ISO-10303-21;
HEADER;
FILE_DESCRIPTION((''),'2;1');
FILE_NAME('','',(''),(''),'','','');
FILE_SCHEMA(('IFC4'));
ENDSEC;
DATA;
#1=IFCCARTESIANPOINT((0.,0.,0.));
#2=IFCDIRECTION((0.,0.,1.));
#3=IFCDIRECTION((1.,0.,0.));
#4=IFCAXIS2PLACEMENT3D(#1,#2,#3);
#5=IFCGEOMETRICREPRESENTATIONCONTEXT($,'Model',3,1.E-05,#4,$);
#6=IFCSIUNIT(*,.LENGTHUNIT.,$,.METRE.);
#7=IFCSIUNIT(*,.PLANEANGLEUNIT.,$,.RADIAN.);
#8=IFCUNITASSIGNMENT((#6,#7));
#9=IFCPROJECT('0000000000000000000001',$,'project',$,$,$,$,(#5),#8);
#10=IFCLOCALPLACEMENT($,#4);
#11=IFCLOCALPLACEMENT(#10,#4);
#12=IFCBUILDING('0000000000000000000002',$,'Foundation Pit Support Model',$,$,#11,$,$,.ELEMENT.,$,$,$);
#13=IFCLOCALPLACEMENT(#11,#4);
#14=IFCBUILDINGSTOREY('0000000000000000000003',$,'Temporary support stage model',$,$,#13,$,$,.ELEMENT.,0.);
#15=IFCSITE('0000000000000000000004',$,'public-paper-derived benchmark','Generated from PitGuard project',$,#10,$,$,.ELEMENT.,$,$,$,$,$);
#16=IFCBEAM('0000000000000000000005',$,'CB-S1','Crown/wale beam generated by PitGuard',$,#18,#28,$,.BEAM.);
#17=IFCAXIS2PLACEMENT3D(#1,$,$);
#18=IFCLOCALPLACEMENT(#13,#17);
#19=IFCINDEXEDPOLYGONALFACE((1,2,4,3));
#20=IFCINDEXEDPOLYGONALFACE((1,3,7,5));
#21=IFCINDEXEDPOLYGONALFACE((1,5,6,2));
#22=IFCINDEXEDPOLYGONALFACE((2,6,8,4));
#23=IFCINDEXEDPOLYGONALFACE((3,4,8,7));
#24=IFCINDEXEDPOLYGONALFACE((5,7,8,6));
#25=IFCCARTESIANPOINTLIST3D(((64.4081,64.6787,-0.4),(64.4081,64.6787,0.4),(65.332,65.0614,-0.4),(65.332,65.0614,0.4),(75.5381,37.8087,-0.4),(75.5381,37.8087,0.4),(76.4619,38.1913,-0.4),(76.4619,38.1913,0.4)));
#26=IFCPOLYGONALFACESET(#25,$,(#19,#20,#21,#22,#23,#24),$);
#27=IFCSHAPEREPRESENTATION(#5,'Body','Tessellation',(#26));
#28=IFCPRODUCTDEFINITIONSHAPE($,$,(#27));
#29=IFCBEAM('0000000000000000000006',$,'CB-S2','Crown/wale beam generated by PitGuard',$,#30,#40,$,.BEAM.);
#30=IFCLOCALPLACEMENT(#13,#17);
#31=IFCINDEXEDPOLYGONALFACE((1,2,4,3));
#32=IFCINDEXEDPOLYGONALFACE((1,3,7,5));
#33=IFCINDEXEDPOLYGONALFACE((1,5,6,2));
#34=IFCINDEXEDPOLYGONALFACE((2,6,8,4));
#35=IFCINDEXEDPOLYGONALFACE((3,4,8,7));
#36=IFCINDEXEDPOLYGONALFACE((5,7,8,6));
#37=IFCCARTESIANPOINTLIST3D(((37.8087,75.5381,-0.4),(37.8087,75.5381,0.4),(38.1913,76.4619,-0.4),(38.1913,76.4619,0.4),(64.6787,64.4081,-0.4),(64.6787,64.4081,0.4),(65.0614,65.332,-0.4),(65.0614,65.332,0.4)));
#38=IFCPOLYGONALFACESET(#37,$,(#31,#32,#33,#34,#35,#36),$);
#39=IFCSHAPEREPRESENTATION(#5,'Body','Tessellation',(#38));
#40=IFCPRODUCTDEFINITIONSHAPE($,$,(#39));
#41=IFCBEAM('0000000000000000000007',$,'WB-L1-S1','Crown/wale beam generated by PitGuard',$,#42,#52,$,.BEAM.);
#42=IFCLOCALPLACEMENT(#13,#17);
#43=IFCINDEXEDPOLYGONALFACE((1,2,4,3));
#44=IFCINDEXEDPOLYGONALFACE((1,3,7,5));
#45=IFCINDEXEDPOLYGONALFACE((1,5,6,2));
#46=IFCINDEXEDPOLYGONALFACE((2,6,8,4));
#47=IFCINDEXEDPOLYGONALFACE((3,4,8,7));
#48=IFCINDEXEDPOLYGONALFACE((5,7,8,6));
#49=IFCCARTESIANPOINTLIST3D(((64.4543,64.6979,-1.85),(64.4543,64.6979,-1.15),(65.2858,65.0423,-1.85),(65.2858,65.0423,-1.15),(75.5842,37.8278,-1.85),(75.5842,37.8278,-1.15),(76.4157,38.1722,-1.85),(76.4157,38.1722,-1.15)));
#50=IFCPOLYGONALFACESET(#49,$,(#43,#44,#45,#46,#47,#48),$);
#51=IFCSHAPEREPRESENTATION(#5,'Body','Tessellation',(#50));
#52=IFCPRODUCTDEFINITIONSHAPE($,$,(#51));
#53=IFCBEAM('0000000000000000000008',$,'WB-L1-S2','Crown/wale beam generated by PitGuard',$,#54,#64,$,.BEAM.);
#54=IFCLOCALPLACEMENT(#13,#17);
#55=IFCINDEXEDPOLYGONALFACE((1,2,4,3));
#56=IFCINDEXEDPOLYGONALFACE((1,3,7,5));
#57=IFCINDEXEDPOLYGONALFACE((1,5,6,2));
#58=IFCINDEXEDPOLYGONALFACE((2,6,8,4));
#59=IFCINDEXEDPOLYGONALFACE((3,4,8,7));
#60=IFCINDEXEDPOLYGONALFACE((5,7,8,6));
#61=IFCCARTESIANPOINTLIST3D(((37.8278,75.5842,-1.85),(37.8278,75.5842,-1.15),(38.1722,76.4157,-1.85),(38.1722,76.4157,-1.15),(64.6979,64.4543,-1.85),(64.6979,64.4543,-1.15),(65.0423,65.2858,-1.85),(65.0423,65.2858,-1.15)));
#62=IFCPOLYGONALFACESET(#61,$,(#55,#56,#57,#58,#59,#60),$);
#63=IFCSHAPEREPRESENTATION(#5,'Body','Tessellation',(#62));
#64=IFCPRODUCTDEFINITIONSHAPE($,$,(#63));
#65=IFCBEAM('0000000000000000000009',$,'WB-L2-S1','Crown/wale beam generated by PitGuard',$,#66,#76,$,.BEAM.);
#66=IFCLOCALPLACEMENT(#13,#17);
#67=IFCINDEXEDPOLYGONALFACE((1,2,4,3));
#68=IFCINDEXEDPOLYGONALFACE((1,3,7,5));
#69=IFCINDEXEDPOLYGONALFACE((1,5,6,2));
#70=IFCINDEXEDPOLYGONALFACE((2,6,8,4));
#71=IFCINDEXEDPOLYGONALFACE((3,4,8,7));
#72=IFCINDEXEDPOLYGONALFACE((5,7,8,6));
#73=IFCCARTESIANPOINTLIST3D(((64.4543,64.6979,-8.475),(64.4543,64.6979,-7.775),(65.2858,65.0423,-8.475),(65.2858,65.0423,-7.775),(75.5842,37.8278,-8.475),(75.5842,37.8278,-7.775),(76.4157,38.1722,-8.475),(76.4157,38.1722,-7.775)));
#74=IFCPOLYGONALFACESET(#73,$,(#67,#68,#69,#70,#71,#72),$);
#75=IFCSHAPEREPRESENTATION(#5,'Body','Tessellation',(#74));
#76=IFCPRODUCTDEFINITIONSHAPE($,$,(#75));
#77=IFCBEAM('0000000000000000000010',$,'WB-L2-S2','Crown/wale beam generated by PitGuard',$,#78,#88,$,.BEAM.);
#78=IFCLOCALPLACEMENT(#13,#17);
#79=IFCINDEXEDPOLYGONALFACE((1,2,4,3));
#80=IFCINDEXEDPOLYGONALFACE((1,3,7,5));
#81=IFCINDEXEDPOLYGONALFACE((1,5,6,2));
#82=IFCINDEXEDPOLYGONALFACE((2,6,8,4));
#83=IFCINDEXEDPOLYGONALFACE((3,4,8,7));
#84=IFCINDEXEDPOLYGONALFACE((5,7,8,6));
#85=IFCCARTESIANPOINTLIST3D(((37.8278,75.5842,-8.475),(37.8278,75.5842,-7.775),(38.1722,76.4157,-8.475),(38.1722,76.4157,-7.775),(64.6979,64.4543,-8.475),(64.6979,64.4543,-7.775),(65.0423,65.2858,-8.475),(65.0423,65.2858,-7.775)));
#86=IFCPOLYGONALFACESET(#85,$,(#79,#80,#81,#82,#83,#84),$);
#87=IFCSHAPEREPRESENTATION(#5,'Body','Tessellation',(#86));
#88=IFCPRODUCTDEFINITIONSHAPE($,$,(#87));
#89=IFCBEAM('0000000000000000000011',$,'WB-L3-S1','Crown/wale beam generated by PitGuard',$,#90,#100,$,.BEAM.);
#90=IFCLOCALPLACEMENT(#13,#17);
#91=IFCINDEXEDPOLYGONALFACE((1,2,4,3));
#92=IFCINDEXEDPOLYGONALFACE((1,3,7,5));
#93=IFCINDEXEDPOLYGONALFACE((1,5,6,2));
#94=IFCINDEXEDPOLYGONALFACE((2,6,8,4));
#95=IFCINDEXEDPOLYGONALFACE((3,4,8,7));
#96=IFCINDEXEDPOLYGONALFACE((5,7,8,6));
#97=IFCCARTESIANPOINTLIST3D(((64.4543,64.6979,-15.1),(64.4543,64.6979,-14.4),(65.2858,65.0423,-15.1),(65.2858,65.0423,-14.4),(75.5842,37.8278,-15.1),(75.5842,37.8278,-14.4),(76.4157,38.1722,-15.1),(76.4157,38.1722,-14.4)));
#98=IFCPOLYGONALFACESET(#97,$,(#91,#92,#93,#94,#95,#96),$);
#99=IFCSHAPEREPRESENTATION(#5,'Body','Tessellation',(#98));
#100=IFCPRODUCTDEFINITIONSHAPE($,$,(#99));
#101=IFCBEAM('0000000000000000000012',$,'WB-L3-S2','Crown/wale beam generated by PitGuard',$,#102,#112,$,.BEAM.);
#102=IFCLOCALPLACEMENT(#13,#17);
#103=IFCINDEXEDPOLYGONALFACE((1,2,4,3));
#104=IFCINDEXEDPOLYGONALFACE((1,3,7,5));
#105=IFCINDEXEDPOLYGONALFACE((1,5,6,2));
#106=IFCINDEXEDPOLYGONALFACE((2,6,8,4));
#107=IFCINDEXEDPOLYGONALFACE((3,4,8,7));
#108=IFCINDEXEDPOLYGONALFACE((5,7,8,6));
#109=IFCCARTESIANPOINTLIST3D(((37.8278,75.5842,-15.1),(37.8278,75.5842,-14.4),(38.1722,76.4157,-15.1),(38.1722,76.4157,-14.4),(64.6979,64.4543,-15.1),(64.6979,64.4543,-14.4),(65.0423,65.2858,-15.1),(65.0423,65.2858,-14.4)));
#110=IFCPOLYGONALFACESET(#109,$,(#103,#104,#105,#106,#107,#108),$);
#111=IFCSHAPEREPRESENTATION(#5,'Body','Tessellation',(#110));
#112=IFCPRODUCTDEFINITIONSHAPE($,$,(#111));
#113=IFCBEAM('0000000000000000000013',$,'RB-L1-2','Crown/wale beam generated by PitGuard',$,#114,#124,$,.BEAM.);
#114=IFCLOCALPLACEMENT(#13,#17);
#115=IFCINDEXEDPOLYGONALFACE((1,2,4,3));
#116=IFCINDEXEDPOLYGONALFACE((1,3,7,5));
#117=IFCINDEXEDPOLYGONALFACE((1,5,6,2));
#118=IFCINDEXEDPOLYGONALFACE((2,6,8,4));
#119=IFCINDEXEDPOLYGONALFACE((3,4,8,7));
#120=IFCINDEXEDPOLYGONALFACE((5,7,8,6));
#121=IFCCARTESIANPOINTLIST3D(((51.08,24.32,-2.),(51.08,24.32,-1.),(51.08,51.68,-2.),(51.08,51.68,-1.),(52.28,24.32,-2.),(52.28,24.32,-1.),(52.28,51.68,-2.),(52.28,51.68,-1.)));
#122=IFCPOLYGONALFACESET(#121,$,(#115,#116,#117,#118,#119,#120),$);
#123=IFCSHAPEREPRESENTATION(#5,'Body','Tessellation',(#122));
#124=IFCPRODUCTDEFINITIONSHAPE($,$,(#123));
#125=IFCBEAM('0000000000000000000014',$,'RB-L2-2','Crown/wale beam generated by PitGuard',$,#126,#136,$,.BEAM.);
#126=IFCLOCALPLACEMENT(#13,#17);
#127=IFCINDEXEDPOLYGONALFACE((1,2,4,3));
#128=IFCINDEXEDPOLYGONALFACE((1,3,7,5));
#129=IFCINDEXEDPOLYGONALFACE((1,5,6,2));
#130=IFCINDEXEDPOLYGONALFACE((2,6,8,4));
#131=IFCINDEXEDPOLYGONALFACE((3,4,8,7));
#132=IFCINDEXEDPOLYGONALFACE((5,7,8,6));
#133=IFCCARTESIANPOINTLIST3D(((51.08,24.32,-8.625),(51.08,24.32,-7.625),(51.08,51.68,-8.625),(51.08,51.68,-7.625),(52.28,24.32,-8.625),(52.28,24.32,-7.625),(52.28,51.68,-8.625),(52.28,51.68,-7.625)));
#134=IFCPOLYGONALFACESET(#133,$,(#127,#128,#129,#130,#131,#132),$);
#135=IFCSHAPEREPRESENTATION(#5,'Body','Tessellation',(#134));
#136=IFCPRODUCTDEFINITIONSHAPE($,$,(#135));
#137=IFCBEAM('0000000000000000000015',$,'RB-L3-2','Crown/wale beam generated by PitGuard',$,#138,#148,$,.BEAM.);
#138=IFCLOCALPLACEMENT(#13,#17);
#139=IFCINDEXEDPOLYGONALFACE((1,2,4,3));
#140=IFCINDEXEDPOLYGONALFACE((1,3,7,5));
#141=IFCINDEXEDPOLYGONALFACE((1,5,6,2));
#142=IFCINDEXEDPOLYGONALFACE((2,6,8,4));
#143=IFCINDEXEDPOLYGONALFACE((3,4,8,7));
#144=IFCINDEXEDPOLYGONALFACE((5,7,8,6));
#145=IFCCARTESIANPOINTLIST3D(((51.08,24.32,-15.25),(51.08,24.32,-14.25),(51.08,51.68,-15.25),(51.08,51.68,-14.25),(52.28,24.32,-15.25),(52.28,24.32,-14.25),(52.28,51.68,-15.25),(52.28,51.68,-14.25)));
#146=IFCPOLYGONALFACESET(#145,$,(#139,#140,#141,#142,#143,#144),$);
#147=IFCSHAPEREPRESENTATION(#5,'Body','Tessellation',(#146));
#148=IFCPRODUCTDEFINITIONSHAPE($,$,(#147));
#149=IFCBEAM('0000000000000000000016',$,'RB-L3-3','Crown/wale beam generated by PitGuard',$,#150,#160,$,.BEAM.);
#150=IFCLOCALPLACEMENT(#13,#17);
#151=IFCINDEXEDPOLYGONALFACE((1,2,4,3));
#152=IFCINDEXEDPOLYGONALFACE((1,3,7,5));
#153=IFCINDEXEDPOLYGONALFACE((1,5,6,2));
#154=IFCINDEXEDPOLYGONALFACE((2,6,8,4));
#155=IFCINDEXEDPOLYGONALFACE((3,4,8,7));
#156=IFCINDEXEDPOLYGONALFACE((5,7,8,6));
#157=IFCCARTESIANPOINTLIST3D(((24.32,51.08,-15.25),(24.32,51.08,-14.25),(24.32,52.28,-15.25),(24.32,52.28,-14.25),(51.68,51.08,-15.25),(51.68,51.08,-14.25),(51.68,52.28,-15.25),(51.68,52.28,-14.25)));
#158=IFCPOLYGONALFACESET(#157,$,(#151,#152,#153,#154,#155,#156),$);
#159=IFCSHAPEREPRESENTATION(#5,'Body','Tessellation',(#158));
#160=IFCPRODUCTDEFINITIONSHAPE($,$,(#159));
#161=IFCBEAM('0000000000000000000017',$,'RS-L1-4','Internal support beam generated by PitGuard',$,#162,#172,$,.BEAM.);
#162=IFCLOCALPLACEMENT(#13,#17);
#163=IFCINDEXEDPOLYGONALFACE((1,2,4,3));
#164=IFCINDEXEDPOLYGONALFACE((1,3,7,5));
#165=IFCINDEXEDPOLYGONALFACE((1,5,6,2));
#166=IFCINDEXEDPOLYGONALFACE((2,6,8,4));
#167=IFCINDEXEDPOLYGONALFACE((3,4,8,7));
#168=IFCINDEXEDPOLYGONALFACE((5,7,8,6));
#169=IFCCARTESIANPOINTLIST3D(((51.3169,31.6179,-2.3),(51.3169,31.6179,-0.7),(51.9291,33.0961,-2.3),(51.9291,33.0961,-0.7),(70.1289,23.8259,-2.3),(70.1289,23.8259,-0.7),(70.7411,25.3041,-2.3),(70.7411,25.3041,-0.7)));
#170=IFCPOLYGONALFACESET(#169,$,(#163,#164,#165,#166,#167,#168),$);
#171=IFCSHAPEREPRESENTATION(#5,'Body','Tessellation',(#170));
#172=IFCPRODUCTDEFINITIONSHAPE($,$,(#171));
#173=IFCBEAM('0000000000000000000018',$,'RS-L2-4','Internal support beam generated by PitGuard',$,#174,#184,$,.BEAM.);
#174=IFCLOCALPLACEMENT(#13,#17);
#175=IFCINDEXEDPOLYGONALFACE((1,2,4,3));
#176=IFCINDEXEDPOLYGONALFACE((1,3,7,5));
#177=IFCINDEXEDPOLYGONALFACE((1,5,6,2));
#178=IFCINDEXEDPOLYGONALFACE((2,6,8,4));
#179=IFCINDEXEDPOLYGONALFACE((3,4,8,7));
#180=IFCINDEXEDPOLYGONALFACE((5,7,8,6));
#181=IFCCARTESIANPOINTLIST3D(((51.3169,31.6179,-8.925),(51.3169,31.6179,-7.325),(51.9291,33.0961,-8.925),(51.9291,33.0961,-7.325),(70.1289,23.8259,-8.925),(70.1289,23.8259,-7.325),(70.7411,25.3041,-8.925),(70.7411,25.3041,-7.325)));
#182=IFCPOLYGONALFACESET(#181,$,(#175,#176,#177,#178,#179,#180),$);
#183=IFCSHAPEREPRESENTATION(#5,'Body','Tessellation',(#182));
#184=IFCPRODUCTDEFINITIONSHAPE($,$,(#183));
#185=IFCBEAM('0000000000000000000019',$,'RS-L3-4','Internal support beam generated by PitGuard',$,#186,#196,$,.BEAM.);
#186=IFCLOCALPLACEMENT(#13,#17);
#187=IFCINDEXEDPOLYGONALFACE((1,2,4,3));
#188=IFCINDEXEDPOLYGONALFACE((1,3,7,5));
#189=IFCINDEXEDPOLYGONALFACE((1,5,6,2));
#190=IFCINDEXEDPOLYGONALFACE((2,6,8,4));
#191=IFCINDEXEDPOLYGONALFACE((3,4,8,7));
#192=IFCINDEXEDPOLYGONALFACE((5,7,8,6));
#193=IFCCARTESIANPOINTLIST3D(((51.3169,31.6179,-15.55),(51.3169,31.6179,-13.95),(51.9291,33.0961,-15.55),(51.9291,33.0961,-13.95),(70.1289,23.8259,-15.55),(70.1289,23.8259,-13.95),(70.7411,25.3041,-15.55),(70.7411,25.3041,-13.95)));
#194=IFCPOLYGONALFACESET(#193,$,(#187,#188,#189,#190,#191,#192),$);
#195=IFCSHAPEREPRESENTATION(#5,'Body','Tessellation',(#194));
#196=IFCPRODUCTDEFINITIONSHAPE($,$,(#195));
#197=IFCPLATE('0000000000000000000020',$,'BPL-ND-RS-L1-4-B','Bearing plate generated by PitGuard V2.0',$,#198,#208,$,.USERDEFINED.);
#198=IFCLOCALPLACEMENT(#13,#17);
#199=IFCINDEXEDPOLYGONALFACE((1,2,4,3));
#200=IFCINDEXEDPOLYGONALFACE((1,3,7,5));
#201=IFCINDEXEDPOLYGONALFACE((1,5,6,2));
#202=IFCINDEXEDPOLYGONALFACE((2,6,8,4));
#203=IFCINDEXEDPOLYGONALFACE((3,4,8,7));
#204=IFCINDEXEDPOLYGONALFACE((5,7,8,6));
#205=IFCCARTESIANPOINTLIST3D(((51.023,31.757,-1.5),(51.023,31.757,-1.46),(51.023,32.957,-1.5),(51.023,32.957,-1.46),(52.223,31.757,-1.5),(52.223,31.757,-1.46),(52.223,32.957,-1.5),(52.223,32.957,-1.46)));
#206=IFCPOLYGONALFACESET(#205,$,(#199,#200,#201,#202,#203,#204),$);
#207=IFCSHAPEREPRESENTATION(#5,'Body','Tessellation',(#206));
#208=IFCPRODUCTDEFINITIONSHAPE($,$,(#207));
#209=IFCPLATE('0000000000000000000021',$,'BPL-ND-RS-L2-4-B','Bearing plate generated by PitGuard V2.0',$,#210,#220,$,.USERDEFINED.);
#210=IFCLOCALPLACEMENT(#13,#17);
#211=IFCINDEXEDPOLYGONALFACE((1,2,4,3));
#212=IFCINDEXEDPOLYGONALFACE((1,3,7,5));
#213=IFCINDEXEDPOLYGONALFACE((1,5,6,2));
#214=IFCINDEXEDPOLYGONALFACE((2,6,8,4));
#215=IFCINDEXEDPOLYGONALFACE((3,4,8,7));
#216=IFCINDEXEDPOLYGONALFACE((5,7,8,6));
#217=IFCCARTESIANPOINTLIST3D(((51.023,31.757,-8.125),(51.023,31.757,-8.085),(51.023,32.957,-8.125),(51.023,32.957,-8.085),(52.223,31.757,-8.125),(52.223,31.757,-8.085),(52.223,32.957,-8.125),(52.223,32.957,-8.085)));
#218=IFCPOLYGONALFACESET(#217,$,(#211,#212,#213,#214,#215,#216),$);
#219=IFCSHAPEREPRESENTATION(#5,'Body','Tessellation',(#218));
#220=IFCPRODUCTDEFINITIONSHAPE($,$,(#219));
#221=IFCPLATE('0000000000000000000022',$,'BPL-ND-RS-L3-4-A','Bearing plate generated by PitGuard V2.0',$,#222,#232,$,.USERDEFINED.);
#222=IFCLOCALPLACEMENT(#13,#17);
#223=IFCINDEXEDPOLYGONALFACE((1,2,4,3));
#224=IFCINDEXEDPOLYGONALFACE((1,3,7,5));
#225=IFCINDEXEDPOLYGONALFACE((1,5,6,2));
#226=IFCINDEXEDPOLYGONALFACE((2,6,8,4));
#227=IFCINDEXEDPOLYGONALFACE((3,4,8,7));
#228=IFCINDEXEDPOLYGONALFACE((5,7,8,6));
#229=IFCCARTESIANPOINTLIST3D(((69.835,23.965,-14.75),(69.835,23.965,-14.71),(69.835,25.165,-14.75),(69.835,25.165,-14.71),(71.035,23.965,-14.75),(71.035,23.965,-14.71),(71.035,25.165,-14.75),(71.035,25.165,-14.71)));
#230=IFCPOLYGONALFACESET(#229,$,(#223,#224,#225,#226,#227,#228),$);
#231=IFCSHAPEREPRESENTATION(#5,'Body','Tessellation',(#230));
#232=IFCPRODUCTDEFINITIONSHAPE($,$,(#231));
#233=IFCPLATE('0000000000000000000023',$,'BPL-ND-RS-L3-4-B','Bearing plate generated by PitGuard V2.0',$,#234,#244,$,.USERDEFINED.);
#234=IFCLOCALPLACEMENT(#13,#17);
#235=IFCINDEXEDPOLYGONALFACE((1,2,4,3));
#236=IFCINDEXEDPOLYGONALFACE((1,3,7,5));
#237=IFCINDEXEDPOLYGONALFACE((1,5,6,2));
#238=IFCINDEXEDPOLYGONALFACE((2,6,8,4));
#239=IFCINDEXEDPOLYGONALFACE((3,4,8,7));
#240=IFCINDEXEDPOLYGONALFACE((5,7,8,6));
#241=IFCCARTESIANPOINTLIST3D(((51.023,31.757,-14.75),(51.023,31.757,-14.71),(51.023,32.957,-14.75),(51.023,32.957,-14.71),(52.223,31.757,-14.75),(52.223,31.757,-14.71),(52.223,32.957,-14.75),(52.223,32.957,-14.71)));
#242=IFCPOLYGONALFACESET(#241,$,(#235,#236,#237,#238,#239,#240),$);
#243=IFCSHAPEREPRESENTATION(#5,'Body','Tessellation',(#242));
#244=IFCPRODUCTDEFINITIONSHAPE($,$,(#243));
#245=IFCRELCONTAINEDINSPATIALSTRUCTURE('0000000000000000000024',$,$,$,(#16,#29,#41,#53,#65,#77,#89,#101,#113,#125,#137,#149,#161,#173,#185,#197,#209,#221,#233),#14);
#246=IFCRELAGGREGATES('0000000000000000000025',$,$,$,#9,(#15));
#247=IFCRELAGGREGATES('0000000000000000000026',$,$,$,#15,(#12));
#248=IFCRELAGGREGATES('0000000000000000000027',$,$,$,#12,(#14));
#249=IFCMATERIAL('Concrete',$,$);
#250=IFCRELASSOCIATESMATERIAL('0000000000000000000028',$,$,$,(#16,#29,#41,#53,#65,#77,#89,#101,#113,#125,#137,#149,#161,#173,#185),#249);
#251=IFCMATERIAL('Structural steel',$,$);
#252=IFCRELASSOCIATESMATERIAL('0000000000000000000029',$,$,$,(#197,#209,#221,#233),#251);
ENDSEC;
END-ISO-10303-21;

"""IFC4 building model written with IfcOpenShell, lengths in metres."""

from ifc_helpers import new_model, si_unit, frame, origin_with_axes, origin_2d, place, context, project, spatial, rectangle, extrude, material, element, save


model = new_model("IFC4")

# Units and contexts
model_context = context("Model", 3, precision=1e-05, world=origin_with_axes())
ifc_project = project(units=[si_unit("LENGTHUNIT", "METRE"), si_unit("PLANEANGLEUNIT", "RADIAN")], contexts=[model_context])

# Site, building, storey
site_placement = place(None, origin_with_axes())
site = spatial("IfcSite", under=ifc_project, at=site_placement, Name="public-paper-derived benchmark", Description="Generated from PitGuard project", CompositionType="ELEMENT")
building_placement = place(site_placement, origin_with_axes())
building = spatial("IfcBuilding", under=site, at=building_placement, Name="Foundation Pit Support Model", CompositionType="ELEMENT")
storey_placement = place(building_placement, origin_with_axes())
storey = spatial("IfcBuildingStorey", under=building, at=storey_placement, Name="Temporary support stage model", CompositionType="ELEMENT", Elevation=0.0)

# Beams
ifc_material_1 = material(Name="Concrete")
for number, where, z_axis, x_axis, name in (
    (1, (70.435, 51.435, -0.4), (0.0, 0.0, 1.0), (-0.382683, 0.92388, 0.0), "CB-S1"),
    (2, (51.435, 70.435, -0.4), (0.0, 0.0, 1.0), (-0.92388, 0.382683, 0.0), "CB-S2"),
):
    element("IfcBeam", number, at=place(storey_placement, frame(where, z_axis=z_axis, x_axis=x_axis)), inside=storey, material=ifc_material_1, Name=name, Description="Crown/wale beam generated by PitGuard", PredefinedType="BEAM", context=model_context, shape_type="SweptSolid", body=[
        extrude(rectangle(XDim=29.0839, YDim=1.0, at=origin_2d()), origin_with_axes(), (0.0, 0.0, 1.0), 0.8),
    ])
for number, where, z_axis, x_axis, name in (
    (3, (70.435, 51.435, -1.85), (0.0, 0.0, 1.0), (-0.382683, 0.92388, 0.0), "WB-L1-S1"),
    (4, (51.435, 70.435, -1.85), (0.0, 0.0, 1.0), (-0.92388, 0.382683, 0.0), "WB-L1-S2"),
    (5, (70.435, 51.435, -8.475), (0.0, 0.0, 1.0), (-0.382683, 0.92388, 0.0), "WB-L2-S1"),
    (6, (51.435, 70.435, -8.475), (0.0, 0.0, 1.0), (-0.92388, 0.382683, 0.0), "WB-L2-S2"),
    (7, (70.435, 51.435, -15.1), (0.0, 0.0, 1.0), (-0.382683, 0.92388, 0.0), "WB-L3-S1"),
    (8, (51.435, 70.435, -15.1), (0.0, 0.0, 1.0), (-0.92388, 0.382683, 0.0), "WB-L3-S2"),
):
    element("IfcBeam", number, at=place(storey_placement, frame(where, z_axis=z_axis, x_axis=x_axis)), inside=storey, material=ifc_material_1, Name=name, Description="Crown/wale beam generated by PitGuard", PredefinedType="BEAM", context=model_context, shape_type="SweptSolid", body=[
        extrude(rectangle(XDim=29.0839, YDim=0.9, at=origin_2d()), origin_with_axes(), (0.0, 0.0, 1.0), 0.7),
    ])
for number, where, z_axis, x_axis, name in (
    (9, (51.68, 38.0, -2.0), (0.0, 0.0, 1.0), (0.0, 1.0, 0.0), "RB-L1-2"),
    (10, (51.68, 38.0, -8.625), (0.0, 0.0, 1.0), (0.0, 1.0, 0.0), "RB-L2-2"),
    (11, (51.68, 38.0, -15.25), (0.0, 0.0, 1.0), (0.0, 1.0, 0.0), "RB-L3-2"),
    (12, (38.0, 51.68, -15.25), (0.0, 0.0, 1.0), (-1.0, 0.0, 0.0), "RB-L3-3"),
):
    element("IfcBeam", number, at=place(storey_placement, frame(where, z_axis=z_axis, x_axis=x_axis)), inside=storey, material=ifc_material_1, Name=name, Description="Crown/wale beam generated by PitGuard", PredefinedType="BEAM", context=model_context, shape_type="SweptSolid", body=[
        extrude(rectangle(XDim=27.36, YDim=1.2, at=origin_2d()), origin_with_axes(), (0.0, 0.0, 1.0), 1.0),
    ])
for number, where, z_axis, x_axis, name in (
    (13, (61.029, 28.461, -2.3), (0.0, 0.0, 1.0), (-0.923883, 0.382676, 0.0), "RS-L1-4"),
    (14, (61.029, 28.461, -8.925), (0.0, 0.0, 1.0), (-0.923883, 0.382676, 0.0), "RS-L2-4"),
    (15, (61.029, 28.461, -15.55), (0.0, 0.0, 1.0), (-0.923883, 0.382676, 0.0), "RS-L3-4"),
):
    element("IfcBeam", number, at=place(storey_placement, frame(where, z_axis=z_axis, x_axis=x_axis)), inside=storey, material=ifc_material_1, Name=name, Description="Internal support beam generated by PitGuard", PredefinedType="BEAM", context=model_context, shape_type="SweptSolid", body=[
        extrude(rectangle(XDim=20.3619, YDim=1.6, at=origin_2d()), origin_with_axes(), (0.0, 0.0, 1.0), 1.6),
    ])

# Plates
ifc_material_2 = material(Name="Structural steel")
for number, where, z_axis, x_axis, name in (
    (16, (51.623, 32.357, -1.5), (0.0, 0.0, 1.0), (1.0, 0.0, 0.0), "BPL-ND-RS-L1-4-B"),
    (17, (51.623, 32.357, -8.125), (0.0, 0.0, 1.0), (1.0, 0.0, 0.0), "BPL-ND-RS-L2-4-B"),
    (18, (70.435, 24.565, -14.75), (0.0, 0.0, 1.0), (1.0, 0.0, 0.0), "BPL-ND-RS-L3-4-A"),
    (19, (51.623, 32.357, -14.75), (0.0, 0.0, 1.0), (1.0, 0.0, 0.0), "BPL-ND-RS-L3-4-B"),
):
    element("IfcPlate", number, at=place(storey_placement, frame(where, z_axis=z_axis, x_axis=x_axis)), inside=storey, material=ifc_material_2, Name=name, Description="Bearing plate generated by PitGuard V2.0", PredefinedType="USERDEFINED", context=model_context, shape_type="SweptSolid", body=[
        extrude(rectangle(XDim=1.2, YDim=1.2, at=origin_2d()), origin_with_axes(), (0.0, 0.0, 1.0), 0.04),
    ])

save(model, "model.ifc")
